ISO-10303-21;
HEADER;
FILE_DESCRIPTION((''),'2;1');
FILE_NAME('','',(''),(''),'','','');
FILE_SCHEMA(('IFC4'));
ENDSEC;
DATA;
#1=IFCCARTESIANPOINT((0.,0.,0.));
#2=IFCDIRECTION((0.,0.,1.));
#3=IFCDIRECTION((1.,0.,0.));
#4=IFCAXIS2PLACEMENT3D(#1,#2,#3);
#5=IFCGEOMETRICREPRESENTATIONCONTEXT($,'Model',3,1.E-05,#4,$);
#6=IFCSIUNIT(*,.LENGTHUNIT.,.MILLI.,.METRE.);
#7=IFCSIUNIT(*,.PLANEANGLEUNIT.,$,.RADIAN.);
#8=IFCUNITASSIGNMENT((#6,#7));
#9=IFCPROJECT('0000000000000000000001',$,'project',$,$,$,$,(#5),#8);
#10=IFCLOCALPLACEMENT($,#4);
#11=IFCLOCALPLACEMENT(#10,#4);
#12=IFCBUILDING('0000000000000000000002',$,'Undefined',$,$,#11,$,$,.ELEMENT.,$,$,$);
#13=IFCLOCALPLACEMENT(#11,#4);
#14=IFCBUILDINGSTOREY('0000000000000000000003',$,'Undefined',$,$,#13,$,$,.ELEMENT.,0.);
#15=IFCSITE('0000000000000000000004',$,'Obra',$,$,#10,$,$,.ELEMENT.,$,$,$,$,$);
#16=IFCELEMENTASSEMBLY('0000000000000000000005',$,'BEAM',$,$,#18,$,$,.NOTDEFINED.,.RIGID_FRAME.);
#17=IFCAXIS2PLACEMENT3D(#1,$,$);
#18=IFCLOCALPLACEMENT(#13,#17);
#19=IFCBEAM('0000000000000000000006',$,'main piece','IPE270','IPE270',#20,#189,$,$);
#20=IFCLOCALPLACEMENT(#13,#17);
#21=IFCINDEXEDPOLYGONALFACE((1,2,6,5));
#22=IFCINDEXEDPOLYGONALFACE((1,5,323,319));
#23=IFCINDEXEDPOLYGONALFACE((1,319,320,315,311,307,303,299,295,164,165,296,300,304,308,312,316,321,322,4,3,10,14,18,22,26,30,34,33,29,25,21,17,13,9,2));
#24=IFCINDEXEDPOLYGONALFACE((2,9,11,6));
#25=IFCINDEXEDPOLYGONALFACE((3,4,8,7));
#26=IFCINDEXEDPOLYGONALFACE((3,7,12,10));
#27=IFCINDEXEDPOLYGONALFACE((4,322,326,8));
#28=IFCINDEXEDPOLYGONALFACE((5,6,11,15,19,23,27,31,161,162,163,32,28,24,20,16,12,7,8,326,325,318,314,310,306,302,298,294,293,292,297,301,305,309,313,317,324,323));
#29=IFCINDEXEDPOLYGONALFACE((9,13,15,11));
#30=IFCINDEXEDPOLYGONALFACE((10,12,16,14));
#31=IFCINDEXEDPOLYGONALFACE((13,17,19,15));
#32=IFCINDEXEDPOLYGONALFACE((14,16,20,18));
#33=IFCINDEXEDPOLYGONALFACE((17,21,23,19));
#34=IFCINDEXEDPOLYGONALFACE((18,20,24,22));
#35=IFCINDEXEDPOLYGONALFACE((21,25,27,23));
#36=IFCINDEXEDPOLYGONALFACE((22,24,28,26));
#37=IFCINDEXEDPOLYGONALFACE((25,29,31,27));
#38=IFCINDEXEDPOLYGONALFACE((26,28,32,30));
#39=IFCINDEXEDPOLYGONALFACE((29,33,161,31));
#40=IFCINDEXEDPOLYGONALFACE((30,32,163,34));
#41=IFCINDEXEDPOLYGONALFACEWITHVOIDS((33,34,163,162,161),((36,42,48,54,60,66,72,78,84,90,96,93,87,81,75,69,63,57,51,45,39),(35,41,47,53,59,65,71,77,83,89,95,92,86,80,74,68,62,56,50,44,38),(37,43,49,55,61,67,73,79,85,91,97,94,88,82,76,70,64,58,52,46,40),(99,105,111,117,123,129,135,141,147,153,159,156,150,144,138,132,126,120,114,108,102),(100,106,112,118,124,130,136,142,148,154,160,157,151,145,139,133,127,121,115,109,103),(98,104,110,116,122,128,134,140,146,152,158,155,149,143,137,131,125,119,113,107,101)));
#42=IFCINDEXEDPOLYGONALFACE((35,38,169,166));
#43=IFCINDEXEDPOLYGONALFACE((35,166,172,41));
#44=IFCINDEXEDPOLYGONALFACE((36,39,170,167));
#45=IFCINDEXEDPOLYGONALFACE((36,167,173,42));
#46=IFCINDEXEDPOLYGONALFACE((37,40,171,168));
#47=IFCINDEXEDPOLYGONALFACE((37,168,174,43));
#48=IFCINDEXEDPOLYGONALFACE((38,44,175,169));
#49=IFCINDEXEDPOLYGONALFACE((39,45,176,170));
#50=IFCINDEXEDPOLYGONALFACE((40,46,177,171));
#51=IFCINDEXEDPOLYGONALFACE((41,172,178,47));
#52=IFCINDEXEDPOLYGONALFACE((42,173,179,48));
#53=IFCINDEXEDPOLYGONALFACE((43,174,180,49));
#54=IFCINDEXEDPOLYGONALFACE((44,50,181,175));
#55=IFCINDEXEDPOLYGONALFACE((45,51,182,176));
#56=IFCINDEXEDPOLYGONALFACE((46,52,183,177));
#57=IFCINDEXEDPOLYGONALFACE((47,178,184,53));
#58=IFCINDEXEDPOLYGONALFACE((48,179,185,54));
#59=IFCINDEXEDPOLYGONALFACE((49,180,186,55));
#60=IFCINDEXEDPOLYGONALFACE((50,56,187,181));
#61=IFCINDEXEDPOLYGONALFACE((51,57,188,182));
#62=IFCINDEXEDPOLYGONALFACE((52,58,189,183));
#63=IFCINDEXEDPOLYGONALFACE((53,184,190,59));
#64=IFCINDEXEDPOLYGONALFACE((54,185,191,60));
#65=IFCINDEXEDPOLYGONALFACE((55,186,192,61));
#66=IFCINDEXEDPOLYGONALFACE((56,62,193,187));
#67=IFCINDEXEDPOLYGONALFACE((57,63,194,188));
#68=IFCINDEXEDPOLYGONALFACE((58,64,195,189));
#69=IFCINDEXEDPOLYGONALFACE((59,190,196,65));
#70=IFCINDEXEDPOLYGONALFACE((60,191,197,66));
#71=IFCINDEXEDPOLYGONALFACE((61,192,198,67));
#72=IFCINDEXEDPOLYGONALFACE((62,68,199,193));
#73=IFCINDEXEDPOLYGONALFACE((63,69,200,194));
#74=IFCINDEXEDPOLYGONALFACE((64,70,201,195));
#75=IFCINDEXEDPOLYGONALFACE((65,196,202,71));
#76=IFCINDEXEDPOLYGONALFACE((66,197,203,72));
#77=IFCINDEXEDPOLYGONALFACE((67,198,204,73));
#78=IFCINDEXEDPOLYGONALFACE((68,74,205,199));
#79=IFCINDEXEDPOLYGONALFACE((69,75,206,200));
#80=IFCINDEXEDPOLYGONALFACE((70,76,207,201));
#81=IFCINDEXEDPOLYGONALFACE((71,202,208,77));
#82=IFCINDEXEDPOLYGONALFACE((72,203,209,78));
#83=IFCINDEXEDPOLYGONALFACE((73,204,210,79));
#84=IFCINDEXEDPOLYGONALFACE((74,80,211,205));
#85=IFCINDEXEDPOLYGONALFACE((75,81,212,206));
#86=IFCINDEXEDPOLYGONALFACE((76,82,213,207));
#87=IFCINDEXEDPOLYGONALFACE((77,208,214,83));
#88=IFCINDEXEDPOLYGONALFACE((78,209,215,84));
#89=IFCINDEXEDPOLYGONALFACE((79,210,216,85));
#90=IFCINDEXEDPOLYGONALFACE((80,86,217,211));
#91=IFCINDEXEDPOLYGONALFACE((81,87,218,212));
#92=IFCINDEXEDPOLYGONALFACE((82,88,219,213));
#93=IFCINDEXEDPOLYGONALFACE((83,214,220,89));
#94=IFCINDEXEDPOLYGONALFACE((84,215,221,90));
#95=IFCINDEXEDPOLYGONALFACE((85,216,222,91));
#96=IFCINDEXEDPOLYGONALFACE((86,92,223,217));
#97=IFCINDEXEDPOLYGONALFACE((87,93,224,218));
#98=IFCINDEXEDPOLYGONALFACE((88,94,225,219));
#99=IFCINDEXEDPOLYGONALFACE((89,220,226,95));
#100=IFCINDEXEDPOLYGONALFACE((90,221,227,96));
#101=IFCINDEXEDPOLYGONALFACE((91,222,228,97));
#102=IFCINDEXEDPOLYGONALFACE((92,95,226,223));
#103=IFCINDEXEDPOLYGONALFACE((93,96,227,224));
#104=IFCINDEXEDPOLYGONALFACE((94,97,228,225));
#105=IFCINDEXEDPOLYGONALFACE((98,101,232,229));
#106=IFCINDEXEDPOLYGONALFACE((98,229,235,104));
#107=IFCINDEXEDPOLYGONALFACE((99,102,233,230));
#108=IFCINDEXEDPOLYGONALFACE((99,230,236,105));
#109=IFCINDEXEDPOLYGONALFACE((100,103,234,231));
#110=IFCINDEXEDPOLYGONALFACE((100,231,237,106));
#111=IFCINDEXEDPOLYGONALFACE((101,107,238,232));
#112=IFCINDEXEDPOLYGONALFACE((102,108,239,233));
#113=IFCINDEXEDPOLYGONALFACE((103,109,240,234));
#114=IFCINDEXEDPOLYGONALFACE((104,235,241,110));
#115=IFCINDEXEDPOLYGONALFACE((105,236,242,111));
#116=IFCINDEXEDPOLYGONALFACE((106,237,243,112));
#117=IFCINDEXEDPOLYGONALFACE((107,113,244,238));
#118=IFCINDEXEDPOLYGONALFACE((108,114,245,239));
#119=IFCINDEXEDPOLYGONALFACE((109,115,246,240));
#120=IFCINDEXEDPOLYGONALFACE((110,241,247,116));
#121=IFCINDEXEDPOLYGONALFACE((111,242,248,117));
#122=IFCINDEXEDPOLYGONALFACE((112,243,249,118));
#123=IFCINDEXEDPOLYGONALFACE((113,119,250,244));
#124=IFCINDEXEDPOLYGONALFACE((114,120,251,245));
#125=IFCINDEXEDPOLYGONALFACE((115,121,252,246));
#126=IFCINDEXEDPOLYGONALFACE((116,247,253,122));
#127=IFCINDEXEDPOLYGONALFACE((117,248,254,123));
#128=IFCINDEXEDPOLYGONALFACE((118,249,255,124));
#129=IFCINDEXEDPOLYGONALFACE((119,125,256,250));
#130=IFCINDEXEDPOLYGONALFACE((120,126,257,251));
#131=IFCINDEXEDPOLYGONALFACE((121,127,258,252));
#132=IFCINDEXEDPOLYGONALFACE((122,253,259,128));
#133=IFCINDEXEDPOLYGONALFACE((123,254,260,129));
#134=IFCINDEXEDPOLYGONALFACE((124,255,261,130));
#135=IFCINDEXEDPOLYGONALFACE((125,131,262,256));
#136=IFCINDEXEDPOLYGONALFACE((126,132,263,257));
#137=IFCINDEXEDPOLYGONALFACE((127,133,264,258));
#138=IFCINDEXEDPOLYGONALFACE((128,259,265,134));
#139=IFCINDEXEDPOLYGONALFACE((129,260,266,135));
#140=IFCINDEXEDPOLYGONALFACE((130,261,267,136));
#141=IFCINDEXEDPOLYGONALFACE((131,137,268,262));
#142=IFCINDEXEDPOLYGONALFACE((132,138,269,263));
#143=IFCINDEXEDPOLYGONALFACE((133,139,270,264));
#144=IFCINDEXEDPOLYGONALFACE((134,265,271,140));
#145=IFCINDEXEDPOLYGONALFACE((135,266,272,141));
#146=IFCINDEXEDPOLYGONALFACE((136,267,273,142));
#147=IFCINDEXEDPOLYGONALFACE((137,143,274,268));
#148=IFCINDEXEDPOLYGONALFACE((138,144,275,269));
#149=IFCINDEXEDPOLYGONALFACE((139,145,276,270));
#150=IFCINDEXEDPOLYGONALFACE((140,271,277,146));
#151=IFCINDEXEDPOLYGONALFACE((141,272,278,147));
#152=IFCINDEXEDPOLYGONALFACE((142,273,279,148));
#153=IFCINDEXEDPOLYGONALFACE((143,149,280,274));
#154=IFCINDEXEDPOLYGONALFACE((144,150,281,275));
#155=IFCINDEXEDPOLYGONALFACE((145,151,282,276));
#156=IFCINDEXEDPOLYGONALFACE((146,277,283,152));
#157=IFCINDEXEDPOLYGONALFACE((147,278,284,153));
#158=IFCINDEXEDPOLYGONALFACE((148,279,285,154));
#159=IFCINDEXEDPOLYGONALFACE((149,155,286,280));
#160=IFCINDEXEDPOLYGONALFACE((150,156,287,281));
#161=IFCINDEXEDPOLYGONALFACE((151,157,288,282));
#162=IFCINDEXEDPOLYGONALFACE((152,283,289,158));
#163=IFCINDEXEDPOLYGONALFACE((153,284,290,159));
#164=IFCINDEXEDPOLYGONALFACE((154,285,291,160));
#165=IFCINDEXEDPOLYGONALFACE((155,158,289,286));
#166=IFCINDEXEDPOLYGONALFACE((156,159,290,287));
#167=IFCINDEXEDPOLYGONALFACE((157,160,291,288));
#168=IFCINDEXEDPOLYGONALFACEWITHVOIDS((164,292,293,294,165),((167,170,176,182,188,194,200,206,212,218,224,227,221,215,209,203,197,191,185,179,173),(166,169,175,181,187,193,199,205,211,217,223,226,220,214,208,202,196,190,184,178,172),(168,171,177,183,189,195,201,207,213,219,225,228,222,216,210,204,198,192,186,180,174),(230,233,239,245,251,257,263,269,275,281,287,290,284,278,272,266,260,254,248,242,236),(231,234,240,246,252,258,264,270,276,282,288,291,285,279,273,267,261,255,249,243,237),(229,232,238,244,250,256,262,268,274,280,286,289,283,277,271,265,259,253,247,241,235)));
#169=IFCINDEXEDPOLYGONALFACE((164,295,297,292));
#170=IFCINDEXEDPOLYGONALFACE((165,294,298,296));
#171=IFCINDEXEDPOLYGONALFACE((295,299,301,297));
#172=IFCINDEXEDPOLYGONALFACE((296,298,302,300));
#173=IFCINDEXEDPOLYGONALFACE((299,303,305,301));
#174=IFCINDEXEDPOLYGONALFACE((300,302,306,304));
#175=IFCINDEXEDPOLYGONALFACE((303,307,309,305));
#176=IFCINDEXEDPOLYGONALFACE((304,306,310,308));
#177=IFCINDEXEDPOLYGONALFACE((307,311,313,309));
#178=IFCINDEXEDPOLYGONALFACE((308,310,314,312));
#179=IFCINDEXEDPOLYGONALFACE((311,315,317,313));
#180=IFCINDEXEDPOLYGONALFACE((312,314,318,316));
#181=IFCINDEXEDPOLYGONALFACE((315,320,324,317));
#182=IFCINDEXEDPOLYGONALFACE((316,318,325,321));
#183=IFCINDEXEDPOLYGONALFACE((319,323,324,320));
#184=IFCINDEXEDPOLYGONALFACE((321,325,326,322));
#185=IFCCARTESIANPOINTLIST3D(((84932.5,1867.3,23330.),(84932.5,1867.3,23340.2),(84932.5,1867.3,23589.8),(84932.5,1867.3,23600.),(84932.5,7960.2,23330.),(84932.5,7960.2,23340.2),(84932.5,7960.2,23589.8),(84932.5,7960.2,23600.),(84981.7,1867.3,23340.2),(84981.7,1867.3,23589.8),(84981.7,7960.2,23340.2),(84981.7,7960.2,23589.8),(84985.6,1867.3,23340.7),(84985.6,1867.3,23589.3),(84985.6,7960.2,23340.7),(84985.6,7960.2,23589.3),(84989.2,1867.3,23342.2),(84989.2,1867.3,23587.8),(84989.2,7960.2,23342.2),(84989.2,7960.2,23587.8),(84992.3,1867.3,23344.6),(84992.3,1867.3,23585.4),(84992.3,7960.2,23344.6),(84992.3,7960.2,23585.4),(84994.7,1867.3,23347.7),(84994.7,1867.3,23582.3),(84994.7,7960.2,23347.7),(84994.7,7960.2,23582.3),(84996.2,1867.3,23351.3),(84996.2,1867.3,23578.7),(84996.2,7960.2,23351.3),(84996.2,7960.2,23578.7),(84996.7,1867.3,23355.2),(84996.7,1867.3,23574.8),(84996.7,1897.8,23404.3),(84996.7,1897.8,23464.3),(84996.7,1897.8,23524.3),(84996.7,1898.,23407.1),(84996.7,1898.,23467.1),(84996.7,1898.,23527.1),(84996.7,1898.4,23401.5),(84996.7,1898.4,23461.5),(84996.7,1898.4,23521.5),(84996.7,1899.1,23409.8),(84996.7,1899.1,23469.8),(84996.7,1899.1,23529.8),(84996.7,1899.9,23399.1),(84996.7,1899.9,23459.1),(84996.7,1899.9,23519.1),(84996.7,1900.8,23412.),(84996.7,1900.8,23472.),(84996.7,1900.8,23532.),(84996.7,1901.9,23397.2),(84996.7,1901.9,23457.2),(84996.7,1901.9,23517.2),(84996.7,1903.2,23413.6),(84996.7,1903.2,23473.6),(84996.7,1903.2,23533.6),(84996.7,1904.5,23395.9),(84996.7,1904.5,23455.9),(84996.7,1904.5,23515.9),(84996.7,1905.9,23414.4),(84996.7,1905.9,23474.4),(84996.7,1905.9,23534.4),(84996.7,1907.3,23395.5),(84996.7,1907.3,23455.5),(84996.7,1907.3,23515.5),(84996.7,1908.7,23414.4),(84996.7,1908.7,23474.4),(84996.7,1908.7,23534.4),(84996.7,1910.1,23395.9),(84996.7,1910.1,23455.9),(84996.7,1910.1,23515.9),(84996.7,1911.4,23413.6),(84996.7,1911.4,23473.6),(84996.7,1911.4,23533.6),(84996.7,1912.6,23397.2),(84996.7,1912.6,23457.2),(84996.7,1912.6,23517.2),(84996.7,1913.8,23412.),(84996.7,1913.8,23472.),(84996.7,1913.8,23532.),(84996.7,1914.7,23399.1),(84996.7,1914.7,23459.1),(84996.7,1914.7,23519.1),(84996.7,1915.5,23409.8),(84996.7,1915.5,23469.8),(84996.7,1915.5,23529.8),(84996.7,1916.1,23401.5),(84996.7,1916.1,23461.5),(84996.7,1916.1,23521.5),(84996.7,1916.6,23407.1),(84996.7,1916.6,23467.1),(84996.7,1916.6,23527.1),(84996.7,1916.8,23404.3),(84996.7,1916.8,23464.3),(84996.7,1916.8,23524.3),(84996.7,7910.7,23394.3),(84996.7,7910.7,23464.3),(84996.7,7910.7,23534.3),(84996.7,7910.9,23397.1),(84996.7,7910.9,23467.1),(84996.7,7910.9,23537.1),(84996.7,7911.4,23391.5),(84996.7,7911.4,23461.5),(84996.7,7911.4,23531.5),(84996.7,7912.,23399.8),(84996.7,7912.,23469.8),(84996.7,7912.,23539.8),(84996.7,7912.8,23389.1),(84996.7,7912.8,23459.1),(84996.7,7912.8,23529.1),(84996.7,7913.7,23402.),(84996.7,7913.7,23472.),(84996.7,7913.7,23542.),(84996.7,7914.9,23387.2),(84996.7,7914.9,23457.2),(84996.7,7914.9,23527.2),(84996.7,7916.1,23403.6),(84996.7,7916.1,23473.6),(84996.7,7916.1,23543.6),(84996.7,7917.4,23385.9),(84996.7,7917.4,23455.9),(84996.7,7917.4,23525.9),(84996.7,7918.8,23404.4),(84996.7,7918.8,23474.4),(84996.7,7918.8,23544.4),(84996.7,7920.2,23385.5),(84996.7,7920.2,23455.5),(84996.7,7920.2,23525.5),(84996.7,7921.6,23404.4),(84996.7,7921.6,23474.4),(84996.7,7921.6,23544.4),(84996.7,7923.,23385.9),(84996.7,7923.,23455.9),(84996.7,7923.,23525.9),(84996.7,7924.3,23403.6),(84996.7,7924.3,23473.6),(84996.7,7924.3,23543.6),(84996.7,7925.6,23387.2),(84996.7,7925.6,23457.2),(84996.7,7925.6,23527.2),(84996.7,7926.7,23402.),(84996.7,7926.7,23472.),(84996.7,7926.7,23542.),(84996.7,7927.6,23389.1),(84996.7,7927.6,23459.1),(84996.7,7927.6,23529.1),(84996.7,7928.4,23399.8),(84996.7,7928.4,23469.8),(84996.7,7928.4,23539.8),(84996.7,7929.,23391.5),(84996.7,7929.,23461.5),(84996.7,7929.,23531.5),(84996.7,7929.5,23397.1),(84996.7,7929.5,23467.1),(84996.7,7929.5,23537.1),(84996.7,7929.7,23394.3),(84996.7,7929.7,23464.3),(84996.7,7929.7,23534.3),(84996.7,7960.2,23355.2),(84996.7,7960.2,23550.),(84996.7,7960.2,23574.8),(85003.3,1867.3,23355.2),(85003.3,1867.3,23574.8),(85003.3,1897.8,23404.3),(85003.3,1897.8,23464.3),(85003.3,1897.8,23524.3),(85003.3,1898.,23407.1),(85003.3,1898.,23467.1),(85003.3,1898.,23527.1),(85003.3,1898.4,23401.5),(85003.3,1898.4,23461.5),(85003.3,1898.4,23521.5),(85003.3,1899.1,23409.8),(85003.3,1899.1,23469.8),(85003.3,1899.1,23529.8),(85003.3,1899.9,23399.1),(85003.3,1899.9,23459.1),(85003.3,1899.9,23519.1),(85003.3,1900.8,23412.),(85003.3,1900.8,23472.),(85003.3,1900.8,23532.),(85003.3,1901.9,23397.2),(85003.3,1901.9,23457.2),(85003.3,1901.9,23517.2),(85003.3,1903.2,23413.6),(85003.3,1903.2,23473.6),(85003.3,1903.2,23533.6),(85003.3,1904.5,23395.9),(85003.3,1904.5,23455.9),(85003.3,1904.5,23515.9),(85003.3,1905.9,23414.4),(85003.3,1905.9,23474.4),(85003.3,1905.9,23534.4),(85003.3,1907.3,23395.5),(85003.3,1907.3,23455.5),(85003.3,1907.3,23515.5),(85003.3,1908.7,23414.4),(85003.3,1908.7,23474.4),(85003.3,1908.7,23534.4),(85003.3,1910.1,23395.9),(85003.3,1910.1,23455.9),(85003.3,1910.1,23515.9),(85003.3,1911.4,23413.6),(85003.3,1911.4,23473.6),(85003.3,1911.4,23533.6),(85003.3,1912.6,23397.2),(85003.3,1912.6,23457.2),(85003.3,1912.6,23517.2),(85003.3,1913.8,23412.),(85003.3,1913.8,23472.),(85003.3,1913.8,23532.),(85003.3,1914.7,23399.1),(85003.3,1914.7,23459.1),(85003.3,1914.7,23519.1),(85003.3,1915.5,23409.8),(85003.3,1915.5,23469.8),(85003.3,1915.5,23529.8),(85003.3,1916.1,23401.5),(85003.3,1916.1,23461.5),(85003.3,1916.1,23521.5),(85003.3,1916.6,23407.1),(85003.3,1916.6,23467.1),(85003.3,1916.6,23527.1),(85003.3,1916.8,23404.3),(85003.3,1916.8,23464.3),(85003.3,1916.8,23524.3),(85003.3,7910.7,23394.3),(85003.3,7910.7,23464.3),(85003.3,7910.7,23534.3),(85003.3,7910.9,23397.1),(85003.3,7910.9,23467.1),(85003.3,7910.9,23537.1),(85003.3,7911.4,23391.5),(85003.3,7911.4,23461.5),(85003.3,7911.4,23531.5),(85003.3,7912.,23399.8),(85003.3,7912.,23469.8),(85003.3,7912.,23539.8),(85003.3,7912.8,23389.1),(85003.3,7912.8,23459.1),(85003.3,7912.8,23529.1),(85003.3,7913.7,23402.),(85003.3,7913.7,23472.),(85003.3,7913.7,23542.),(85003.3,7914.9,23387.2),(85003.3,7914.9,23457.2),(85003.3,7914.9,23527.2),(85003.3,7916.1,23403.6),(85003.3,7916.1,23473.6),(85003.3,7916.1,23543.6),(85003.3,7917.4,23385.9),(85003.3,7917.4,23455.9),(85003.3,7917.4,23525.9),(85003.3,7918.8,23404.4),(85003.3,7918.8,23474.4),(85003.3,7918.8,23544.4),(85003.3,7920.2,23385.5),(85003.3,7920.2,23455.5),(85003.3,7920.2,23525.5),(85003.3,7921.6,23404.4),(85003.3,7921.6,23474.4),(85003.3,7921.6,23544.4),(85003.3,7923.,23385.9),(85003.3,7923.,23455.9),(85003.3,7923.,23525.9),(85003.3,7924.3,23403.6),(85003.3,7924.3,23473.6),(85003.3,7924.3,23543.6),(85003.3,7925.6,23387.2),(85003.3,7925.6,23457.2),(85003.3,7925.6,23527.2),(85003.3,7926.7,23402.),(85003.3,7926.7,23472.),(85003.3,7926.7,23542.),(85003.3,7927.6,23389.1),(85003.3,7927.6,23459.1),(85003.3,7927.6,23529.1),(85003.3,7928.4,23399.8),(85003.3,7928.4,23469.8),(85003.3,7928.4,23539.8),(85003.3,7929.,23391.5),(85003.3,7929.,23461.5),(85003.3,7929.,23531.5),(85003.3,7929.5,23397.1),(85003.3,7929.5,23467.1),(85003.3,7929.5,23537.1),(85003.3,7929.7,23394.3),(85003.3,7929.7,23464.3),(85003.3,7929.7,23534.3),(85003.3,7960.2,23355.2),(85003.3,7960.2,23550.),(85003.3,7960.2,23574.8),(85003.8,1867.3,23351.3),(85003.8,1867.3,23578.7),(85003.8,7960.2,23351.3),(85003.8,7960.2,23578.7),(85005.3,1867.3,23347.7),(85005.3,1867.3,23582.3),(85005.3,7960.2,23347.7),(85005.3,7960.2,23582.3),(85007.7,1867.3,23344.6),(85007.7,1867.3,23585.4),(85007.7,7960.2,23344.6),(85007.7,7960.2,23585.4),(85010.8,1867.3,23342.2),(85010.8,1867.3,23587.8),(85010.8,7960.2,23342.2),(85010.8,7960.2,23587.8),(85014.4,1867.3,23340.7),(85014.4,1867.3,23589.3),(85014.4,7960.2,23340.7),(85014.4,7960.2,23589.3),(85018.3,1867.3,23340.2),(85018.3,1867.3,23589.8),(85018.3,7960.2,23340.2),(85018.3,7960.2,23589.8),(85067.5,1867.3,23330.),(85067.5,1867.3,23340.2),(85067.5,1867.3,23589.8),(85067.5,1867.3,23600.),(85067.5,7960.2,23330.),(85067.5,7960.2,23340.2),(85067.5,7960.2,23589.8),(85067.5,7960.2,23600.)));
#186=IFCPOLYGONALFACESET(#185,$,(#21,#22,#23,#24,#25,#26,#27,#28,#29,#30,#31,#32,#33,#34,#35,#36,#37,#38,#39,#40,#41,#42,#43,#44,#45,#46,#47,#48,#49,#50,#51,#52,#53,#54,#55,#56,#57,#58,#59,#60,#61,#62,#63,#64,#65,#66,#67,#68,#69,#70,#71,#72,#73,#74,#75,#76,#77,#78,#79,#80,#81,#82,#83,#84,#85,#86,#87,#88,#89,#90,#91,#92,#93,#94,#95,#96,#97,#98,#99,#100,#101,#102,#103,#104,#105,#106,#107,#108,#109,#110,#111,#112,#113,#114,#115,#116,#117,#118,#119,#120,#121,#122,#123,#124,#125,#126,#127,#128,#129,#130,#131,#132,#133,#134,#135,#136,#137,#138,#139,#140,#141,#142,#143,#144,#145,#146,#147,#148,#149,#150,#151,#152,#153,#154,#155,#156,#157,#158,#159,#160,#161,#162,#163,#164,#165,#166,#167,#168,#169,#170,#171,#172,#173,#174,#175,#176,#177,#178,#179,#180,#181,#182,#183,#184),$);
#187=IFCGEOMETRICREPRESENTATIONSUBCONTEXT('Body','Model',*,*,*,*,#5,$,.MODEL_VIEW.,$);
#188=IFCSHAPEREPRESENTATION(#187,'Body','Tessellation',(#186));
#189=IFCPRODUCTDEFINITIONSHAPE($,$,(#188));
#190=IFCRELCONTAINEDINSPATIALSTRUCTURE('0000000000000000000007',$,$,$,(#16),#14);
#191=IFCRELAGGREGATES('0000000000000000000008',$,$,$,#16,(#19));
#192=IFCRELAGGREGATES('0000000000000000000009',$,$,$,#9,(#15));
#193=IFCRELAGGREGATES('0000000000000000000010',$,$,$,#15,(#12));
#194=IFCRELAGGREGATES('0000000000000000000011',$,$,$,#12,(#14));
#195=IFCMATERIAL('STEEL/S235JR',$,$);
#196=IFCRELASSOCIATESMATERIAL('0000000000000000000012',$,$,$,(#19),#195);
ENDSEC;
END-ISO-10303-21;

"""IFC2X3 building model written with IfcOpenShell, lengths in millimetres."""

from ifc_helpers import new_model, si_unit, frame, origin_with_axes, origin_2d_with_axis, place, context, subcontext, project, spatial, rectangle, circle, i_section, extrude, clip, halfspace, source, transform, mapped, material, element, aggregate, save


model = new_model("IFC2X3")

# Units and contexts
model_context = context("Model", 3, precision=1e-05, world=origin_with_axes())
body_context = subcontext(model_context, "Body", "Model", "MODEL_VIEW")
ifc_project = project(units=[si_unit("LENGTHUNIT", "METRE", prefix="MILLI"), si_unit("PLANEANGLEUNIT", "RADIAN")], contexts=[model_context])

# Site, building, storey
site_placement = place(None, origin_with_axes())
site = spatial("IfcSite", under=ifc_project, at=site_placement, Name="Obra", CompositionType="ELEMENT")
building_placement = place(site_placement, origin_with_axes())
building = spatial("IfcBuilding", under=site, at=building_placement, Name="Undefined", CompositionType="ELEMENT")
storey_placement = place(building_placement, origin_with_axes())
storey = spatial("IfcBuildingStorey", under=building, at=storey_placement, Name="Undefined", CompositionType="ELEMENT", Elevation=0.0)

# Element assembly, beam, openings
ifc_material_1 = material(Name="STEEL/S235JR")
shared_shape_1 = source(origin_with_axes(), body_context, "Body", "SweptSolid", [
    extrude(circle(Radius=9.5, at=origin_2d_with_axis()), frame((0.0, -3.4, 0.0), z_axis=(0.0, 1.0, 0.0), x_axis=(1.0, 0.0, 0.0)), (0.0, 0.0, 1.0), 6.8),
])
assembly_1_placement = place(storey_placement, origin_with_axes())
assembly_1 = element("IfcElementAssembly", 1, at=assembly_1_placement, inside=storey, Name="BEAM", AssemblyPlace="NOTDEFINED", PredefinedType="RIGID_FRAME")
beam_1_placement = place(assembly_1_placement, frame((85000.0, 7957.5, 23465.0), z_axis=(0.0, 0.0, 1.0), x_axis=(0.0, -1.0, 0.0)))
beam_1 = element("IfcBeam", 2, at=beam_1_placement, material=ifc_material_1, Name="main piece", Description="IPE270", ObjectType="IPE270", context=body_context, shape_type="Clipping", body=[
    clip(clip(extrude(i_section(OverallWidth=135.0, OverallDepth=270.0, WebThickness=6.6, FlangeThickness=10.2, FilletRadius=15.0, at=origin_2d_with_axis()), frame((6090.2, 0.0, 0.0), z_axis=(-1.0, 0.0, 0.0), x_axis=(0.0, -1.0, 0.0)), (0.0, 0.0, 1.0), 6092.9), halfspace(frame((6090.2, 0.0, -235.0), z_axis=(-1.0, 0.0, 0.0), x_axis=(0.0, 1.0, 0.0)), True)), halfspace(frame((-2.7, 0.0, -235.0), z_axis=(1.0, 0.0, 0.0), x_axis=(0.0, -1.0, 0.0)), True)),
])
opening_1_placement = place(assembly_1_placement, frame((85000.0, 7957.5, 23465.0), z_axis=(0.0, 0.0, 1.0), x_axis=(0.0, -1.0, 0.0)))
element("IfcOpeningElement", 3, at=opening_1_placement, cuts=beam_1, ObjectType="Recess", context=body_context, shape_type="SweptSolid", body=[
    extrude(rectangle(XDim=51.0, YDim=156.0, at=origin_2d_with_axis()), frame((-80.7, -68.5, 110.5), z_axis=(0.0, 1.0, 0.0), x_axis=(0.0, 0.0, -1.0)), (0.0, 0.0, 1.0), 137.0),
])
opening_2_placement = place(assembly_1_placement, frame((85000.0, 1867.3, 23600.0), z_axis=(0.0, 1.0, 0.0), x_axis=(0.0, 0.0, -1.0)))
element("IfcOpeningElement", 4, at=opening_2_placement, cuts=beam_1, ObjectType="Opening", context=body_context, shape_type="MappedRepresentation", body=[
    mapped(shared_shape_1, transform((75.0, 0.0, 40.0))),
    mapped(shared_shape_1, transform((135.0, 0.0, 40.0))),
    mapped(shared_shape_1, transform((195.0, 0.0, 40.0))),
])
opening_3_placement = place(assembly_1_placement, frame((85000.0, 7960.2, 23570.0), z_axis=(0.0, -1.0, 0.0), x_axis=(0.0, 0.0, -1.0)))
element("IfcOpeningElement", 5, at=opening_3_placement, cuts=beam_1, ObjectType="Opening", context=body_context, shape_type="MappedRepresentation", body=[
    mapped(shared_shape_1, transform((35.0, 0.0, 40.0))),
    mapped(shared_shape_1, transform((105.0, 0.0, 40.0))),
    mapped(shared_shape_1, transform((175.0, 0.0, 40.0))),
])

aggregate(assembly_1, [beam_1])

save(model, "model.ifc")
